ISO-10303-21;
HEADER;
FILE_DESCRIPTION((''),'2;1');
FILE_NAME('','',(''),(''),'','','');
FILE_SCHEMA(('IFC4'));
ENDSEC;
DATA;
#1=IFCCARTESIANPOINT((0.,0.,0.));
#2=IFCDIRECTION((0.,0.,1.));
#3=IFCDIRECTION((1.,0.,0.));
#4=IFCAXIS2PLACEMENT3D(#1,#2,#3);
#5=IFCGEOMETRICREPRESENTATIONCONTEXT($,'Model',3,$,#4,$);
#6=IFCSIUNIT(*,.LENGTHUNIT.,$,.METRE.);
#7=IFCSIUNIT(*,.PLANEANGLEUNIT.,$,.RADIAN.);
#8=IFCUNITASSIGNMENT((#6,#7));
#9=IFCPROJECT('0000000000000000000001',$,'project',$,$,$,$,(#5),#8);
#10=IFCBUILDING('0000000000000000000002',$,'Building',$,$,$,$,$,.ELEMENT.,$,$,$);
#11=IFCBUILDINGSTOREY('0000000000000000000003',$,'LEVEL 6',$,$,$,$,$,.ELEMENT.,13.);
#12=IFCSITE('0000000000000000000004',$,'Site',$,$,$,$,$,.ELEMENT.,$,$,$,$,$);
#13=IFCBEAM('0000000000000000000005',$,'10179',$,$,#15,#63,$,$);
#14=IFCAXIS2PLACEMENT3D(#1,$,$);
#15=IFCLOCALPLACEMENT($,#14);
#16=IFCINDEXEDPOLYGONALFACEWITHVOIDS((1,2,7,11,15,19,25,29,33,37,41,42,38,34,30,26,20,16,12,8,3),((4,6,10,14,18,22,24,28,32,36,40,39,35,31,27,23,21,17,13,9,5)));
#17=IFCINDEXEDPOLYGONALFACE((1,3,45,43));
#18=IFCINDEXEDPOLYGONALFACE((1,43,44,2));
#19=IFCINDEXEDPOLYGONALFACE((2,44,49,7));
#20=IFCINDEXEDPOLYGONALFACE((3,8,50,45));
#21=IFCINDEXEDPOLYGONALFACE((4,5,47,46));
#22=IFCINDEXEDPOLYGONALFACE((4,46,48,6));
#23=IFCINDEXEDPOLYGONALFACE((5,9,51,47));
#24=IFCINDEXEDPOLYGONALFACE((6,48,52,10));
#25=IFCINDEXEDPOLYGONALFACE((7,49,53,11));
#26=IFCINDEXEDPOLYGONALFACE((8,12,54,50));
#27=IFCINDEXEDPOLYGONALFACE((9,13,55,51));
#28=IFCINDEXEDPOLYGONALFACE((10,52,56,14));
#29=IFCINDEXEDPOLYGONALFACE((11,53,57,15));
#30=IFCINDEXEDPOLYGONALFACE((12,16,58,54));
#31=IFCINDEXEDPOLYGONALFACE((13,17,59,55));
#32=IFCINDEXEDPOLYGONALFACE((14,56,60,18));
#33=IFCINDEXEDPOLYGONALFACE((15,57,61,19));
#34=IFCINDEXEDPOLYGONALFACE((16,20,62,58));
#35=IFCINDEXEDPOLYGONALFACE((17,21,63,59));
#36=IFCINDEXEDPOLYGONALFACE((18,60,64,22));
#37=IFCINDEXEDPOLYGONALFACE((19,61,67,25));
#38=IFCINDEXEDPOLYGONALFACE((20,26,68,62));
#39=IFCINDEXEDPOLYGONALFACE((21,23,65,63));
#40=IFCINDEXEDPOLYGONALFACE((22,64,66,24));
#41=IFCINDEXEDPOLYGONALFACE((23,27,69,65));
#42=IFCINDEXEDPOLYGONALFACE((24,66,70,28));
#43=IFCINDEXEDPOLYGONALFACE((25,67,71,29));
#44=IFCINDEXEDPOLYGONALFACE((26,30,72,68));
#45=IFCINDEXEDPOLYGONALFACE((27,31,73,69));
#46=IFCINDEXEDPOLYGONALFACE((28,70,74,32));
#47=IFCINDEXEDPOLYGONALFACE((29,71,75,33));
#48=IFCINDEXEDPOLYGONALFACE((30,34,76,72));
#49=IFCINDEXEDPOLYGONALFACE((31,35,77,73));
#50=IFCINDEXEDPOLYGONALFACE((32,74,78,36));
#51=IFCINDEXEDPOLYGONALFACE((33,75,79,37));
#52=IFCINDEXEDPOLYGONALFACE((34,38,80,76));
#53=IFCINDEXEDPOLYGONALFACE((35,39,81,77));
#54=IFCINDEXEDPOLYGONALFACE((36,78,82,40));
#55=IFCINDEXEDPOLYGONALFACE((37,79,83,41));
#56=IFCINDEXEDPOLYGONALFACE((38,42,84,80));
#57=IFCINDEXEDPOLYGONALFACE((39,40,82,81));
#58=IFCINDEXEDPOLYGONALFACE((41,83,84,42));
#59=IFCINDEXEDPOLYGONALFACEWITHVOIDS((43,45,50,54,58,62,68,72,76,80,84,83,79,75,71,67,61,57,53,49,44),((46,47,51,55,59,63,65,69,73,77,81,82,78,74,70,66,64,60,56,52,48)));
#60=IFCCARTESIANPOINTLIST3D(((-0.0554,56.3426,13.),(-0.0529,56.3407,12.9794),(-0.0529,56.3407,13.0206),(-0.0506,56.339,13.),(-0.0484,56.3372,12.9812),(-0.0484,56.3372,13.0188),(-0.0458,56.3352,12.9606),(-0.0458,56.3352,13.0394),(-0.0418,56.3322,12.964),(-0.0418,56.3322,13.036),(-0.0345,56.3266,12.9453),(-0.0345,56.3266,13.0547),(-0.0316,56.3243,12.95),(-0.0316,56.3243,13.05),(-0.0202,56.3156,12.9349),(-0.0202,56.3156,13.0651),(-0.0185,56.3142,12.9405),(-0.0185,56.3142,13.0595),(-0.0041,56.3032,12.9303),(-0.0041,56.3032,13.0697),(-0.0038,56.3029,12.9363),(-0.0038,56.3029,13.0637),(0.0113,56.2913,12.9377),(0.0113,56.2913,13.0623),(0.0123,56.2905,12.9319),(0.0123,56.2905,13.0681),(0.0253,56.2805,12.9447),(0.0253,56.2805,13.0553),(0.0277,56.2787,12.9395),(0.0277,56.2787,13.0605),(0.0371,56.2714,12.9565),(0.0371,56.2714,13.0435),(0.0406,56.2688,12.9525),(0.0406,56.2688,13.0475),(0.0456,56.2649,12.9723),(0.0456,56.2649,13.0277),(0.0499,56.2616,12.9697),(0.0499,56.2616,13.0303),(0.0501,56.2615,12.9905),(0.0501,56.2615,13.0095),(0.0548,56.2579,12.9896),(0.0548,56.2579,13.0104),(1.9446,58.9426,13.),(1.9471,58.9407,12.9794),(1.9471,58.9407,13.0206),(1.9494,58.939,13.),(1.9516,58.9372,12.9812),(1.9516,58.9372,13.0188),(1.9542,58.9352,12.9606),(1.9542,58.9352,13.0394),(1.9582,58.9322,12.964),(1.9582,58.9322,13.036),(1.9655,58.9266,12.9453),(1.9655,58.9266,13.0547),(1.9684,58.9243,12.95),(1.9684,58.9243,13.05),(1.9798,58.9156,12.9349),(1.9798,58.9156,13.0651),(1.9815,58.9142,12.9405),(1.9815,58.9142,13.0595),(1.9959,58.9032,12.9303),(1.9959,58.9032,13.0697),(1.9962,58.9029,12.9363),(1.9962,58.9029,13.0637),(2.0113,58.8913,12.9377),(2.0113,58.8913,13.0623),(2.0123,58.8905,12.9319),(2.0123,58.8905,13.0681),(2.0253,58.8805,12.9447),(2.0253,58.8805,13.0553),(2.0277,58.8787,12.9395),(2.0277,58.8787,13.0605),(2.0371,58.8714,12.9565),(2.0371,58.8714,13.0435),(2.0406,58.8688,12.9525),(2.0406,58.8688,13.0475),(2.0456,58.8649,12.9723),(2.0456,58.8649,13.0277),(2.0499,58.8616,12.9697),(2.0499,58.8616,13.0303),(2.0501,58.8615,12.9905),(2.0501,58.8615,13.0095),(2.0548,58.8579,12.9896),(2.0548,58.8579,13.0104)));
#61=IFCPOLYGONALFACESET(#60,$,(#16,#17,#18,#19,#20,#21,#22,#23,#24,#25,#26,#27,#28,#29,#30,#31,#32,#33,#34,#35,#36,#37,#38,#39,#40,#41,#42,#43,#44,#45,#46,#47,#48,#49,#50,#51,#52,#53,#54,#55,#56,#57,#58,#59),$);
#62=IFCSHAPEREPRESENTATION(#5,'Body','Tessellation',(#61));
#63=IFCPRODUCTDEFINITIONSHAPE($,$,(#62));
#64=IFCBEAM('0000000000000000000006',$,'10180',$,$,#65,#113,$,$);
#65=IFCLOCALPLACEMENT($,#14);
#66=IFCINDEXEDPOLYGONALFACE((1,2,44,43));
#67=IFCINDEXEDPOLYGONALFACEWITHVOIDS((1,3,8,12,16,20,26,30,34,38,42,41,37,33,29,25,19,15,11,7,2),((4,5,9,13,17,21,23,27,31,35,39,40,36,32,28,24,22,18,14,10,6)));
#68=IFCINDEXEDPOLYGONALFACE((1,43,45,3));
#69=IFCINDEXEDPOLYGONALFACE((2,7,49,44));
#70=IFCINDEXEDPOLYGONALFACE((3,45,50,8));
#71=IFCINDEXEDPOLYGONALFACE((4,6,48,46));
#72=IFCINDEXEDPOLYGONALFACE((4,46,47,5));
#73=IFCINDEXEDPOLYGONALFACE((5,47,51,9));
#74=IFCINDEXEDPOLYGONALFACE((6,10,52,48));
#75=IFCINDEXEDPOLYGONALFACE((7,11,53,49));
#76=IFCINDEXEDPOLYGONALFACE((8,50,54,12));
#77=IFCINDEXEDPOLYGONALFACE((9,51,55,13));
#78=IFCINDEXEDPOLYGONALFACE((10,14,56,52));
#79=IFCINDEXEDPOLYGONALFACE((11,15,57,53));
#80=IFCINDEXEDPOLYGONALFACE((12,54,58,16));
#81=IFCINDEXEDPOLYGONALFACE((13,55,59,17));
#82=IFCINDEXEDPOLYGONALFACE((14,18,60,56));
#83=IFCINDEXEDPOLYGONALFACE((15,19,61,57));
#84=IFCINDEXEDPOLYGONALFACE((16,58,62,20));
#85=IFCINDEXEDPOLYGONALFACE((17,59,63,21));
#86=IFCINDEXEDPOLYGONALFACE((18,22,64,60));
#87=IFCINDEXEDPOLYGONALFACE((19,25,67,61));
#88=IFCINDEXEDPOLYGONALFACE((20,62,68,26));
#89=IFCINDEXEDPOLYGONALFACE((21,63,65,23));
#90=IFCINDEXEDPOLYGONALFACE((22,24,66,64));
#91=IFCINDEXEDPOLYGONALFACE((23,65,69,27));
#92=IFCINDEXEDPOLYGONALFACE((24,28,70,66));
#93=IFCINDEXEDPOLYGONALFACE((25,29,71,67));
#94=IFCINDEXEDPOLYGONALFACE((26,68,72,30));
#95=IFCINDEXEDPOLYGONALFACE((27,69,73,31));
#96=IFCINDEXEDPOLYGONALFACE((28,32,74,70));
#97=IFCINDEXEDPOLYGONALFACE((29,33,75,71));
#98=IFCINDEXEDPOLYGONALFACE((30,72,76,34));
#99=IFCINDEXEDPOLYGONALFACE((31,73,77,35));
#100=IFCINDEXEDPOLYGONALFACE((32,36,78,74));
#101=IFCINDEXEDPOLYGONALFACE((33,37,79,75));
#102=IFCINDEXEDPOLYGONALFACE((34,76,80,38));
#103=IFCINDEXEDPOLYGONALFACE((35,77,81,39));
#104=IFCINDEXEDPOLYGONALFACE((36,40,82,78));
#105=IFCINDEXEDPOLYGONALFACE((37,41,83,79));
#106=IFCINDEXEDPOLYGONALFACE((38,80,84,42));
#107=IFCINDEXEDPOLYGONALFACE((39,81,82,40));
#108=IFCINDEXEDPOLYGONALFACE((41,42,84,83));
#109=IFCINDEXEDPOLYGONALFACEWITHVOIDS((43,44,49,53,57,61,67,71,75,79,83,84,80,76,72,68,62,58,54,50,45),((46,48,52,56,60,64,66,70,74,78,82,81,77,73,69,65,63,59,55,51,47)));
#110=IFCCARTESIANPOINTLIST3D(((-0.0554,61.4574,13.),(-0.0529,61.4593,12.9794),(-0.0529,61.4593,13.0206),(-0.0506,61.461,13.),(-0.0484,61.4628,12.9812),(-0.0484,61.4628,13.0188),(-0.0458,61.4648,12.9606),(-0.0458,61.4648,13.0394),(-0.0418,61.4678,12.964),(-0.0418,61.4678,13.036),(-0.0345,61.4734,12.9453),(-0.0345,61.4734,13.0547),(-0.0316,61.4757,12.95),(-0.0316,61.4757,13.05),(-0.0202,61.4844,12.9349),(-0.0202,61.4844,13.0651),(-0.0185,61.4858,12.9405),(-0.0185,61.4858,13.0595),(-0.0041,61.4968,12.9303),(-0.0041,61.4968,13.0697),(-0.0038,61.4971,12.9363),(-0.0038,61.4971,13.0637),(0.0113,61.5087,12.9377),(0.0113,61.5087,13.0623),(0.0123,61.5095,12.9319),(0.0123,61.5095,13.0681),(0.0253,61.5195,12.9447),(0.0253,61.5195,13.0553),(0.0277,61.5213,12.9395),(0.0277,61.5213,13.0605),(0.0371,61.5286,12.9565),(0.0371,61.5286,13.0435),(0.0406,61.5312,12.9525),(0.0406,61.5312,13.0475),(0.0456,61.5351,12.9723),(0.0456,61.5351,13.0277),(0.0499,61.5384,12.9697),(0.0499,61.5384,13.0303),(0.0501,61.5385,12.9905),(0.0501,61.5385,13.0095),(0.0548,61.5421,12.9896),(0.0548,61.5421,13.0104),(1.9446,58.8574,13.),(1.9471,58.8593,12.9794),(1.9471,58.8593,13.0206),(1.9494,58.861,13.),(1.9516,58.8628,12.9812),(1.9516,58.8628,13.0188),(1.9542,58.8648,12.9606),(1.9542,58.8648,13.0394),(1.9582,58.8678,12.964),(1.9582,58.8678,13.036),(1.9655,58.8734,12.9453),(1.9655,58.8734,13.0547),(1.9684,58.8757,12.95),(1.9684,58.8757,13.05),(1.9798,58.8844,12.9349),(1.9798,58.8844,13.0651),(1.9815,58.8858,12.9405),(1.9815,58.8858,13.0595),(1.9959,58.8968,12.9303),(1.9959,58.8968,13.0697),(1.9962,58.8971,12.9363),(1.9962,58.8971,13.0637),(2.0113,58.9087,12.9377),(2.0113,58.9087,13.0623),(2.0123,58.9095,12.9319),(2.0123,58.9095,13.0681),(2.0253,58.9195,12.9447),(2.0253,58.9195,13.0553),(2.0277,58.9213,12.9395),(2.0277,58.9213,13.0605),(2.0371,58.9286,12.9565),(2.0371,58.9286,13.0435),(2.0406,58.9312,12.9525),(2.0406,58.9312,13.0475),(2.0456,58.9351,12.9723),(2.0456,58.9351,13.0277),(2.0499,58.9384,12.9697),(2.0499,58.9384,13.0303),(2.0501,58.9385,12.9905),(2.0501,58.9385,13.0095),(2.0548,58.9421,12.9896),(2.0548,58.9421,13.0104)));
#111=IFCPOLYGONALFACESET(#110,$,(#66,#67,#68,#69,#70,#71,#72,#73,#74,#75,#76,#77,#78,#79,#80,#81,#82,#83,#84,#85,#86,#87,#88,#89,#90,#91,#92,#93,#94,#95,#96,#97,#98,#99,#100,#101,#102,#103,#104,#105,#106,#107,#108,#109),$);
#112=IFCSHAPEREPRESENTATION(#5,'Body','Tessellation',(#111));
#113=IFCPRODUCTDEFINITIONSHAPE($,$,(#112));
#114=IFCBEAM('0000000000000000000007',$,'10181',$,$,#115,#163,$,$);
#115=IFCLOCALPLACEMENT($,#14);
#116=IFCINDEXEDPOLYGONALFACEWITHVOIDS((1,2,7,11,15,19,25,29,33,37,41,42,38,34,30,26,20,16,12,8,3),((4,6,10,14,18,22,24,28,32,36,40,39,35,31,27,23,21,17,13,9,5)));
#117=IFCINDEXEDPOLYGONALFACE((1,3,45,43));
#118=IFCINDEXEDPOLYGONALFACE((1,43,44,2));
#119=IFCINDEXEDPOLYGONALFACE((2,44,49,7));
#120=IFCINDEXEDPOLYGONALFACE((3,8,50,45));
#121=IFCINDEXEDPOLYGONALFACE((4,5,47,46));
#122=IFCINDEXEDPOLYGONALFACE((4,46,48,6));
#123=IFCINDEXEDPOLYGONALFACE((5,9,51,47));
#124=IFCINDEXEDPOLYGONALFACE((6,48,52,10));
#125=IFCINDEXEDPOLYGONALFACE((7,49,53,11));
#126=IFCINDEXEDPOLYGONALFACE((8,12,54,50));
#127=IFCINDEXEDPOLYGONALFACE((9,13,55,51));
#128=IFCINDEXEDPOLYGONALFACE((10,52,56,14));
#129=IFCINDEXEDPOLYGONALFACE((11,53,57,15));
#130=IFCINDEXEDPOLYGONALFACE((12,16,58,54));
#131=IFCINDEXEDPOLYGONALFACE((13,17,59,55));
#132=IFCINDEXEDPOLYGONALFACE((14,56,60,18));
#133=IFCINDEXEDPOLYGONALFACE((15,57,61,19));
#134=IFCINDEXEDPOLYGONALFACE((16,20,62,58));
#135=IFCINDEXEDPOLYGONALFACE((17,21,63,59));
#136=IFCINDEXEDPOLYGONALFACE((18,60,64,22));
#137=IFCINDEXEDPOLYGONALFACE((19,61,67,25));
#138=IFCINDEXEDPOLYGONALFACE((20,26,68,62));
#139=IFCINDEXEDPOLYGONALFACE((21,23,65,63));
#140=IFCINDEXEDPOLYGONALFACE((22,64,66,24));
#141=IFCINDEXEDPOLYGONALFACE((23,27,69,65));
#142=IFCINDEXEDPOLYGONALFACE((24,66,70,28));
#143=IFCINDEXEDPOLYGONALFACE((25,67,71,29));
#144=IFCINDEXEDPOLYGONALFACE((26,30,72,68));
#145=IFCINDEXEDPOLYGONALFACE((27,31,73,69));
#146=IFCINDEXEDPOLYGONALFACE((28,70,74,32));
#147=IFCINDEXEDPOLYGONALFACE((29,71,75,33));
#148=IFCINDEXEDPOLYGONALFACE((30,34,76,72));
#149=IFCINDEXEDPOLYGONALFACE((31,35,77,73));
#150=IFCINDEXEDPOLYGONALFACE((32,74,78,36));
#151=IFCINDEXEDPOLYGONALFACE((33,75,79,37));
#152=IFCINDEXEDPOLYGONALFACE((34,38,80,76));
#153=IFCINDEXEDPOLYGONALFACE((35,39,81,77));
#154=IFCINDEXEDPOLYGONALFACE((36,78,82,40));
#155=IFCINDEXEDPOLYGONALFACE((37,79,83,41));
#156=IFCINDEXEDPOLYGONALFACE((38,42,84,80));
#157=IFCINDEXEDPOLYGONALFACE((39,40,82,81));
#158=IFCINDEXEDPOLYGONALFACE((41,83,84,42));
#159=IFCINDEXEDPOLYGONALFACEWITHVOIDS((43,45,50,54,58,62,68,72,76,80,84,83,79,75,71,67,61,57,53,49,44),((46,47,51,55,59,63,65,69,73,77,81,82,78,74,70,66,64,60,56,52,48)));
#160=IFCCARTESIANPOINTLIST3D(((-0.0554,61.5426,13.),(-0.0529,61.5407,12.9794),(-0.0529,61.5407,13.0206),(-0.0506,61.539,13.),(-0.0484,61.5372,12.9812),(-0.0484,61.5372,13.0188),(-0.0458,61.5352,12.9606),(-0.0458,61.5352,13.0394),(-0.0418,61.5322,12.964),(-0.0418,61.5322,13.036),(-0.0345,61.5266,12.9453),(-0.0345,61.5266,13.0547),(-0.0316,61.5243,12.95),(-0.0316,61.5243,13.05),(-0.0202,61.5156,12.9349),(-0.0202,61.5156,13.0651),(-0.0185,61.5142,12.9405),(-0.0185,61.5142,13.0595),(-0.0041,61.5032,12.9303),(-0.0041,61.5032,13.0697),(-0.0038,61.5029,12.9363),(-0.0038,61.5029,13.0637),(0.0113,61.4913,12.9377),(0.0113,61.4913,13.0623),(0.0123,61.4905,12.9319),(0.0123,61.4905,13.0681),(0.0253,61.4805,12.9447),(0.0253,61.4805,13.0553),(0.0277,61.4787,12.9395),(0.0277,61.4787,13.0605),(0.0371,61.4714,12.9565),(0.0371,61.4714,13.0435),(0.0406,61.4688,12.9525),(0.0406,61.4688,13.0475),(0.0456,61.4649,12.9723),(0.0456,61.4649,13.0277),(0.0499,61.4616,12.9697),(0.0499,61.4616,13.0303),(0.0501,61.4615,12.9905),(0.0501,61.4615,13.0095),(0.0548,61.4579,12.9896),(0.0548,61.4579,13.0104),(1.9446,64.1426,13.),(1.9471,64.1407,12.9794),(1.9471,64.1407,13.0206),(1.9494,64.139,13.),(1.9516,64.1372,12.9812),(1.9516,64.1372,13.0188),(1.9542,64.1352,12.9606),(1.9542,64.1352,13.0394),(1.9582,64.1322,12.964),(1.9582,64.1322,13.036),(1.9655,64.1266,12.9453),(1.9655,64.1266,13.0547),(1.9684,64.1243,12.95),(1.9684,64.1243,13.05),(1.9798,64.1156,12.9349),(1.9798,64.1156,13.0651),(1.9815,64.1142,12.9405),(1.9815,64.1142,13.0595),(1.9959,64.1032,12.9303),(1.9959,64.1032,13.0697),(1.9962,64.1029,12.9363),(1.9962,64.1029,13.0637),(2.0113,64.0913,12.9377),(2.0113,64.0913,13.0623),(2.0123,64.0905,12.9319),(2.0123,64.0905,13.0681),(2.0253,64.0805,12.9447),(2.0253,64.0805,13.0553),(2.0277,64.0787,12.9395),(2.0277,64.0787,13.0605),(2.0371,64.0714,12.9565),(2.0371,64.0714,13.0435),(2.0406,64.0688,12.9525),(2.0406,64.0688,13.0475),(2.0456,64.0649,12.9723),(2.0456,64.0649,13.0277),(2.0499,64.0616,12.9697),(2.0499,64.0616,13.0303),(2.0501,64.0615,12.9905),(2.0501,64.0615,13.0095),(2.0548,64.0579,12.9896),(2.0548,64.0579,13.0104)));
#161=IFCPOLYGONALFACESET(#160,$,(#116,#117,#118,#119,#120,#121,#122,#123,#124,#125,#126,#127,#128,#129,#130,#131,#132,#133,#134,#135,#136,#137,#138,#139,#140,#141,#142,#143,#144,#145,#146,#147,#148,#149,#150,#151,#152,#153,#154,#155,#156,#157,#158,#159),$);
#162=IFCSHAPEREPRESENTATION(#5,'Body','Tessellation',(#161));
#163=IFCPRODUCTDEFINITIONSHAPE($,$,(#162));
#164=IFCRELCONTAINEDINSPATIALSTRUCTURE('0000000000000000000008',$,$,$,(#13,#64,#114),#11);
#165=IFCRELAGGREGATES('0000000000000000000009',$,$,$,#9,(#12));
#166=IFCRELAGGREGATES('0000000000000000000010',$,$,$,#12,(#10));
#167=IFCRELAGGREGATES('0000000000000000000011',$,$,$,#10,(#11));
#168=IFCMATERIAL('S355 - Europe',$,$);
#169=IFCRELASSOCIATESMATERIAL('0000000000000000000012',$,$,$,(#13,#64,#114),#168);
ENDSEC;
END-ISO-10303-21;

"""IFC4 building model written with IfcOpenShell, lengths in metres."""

from ifc_helpers import new_model, si_unit, frame, origin_with_axes, origin_2d_with_axis, place, context, project, spatial, hollow_circle, extrude, material, material_profile, profile_set, profile_usage, element, save


model = new_model("IFC4")

# Units and contexts
model_context = context("Model", 3, world=origin_with_axes())
ifc_project = project(units=[si_unit("LENGTHUNIT", "METRE"), si_unit("PLANEANGLEUNIT", "RADIAN")], contexts=[model_context])

# Site, building, storey
site = spatial("IfcSite", under=ifc_project, Name="Site", CompositionType="ELEMENT")
building = spatial("IfcBuilding", under=site, Name="Building", CompositionType="ELEMENT")
storey = spatial("IfcBuildingStorey", under=building, Name="LEVEL 6", CompositionType="ELEMENT", Elevation=13.0)

# Shared definitions
ifc_material = material(Name="S355 - Europe")

# Beams
ifc_material_profile_1 = material_profile(ifc_material, hollow_circle(Radius=0.0699, WallThickness=0.006, at=origin_2d_with_axis()))
ifc_profile_set_1 = profile_set([ifc_material_profile_1])
ifc_profile_usage_1 = profile_usage(ifc_profile_set_1, cardinal=10)
beam_1_placement = place(None, frame((0.0, 56.3, 13.0), z_axis=(0.609711, 0.792624, 0.0), x_axis=(-0.792624, 0.609711, 0.0)))
element("IfcBeam", 1, at=beam_1_placement, inside=storey, material=ifc_profile_usage_1, Name="10179", context=model_context, shape_type="SweptSolid", body=[
    extrude(hollow_circle(Radius=0.0699, WallThickness=0.006, at=origin_2d_with_axis()), origin_with_axes(), (0.0, 0.0, 1.0), 3.2802),
])
ifc_material_profile_2 = material_profile(ifc_material, hollow_circle(Radius=0.0699, WallThickness=0.006, at=origin_2d_with_axis()))
ifc_profile_set_2 = profile_set([ifc_material_profile_2])
ifc_profile_usage_2 = profile_usage(ifc_profile_set_2, cardinal=10)
beam_2_placement = place(None, frame((2.0, 58.9, 13.0), z_axis=(-0.609711, 0.792624, 0.0), x_axis=(-0.792624, -0.609711, 0.0)))
element("IfcBeam", 2, at=beam_2_placement, inside=storey, material=ifc_profile_usage_2, Name="10180", context=model_context, shape_type="SweptSolid", body=[
    extrude(hollow_circle(Radius=0.0699, WallThickness=0.006, at=origin_2d_with_axis()), origin_with_axes(), (0.0, 0.0, 1.0), 3.2802),
])
ifc_material_profile_3 = material_profile(ifc_material, hollow_circle(Radius=0.0699, WallThickness=0.006, at=origin_2d_with_axis()))
ifc_profile_set_3 = profile_set([ifc_material_profile_3])
ifc_profile_usage_3 = profile_usage(ifc_profile_set_3, cardinal=10)
beam_3_placement = place(None, frame((0.0, 61.5, 13.0), z_axis=(0.609711, 0.792624, 0.0), x_axis=(-0.792624, 0.609711, 0.0)))
element("IfcBeam", 3, at=beam_3_placement, inside=storey, material=ifc_profile_usage_3, Name="10181", context=model_context, shape_type="SweptSolid", body=[
    extrude(hollow_circle(Radius=0.0699, WallThickness=0.006, at=origin_2d_with_axis()), origin_with_axes(), (0.0, 0.0, 1.0), 3.2802),
])

save(model, "model.ifc")
